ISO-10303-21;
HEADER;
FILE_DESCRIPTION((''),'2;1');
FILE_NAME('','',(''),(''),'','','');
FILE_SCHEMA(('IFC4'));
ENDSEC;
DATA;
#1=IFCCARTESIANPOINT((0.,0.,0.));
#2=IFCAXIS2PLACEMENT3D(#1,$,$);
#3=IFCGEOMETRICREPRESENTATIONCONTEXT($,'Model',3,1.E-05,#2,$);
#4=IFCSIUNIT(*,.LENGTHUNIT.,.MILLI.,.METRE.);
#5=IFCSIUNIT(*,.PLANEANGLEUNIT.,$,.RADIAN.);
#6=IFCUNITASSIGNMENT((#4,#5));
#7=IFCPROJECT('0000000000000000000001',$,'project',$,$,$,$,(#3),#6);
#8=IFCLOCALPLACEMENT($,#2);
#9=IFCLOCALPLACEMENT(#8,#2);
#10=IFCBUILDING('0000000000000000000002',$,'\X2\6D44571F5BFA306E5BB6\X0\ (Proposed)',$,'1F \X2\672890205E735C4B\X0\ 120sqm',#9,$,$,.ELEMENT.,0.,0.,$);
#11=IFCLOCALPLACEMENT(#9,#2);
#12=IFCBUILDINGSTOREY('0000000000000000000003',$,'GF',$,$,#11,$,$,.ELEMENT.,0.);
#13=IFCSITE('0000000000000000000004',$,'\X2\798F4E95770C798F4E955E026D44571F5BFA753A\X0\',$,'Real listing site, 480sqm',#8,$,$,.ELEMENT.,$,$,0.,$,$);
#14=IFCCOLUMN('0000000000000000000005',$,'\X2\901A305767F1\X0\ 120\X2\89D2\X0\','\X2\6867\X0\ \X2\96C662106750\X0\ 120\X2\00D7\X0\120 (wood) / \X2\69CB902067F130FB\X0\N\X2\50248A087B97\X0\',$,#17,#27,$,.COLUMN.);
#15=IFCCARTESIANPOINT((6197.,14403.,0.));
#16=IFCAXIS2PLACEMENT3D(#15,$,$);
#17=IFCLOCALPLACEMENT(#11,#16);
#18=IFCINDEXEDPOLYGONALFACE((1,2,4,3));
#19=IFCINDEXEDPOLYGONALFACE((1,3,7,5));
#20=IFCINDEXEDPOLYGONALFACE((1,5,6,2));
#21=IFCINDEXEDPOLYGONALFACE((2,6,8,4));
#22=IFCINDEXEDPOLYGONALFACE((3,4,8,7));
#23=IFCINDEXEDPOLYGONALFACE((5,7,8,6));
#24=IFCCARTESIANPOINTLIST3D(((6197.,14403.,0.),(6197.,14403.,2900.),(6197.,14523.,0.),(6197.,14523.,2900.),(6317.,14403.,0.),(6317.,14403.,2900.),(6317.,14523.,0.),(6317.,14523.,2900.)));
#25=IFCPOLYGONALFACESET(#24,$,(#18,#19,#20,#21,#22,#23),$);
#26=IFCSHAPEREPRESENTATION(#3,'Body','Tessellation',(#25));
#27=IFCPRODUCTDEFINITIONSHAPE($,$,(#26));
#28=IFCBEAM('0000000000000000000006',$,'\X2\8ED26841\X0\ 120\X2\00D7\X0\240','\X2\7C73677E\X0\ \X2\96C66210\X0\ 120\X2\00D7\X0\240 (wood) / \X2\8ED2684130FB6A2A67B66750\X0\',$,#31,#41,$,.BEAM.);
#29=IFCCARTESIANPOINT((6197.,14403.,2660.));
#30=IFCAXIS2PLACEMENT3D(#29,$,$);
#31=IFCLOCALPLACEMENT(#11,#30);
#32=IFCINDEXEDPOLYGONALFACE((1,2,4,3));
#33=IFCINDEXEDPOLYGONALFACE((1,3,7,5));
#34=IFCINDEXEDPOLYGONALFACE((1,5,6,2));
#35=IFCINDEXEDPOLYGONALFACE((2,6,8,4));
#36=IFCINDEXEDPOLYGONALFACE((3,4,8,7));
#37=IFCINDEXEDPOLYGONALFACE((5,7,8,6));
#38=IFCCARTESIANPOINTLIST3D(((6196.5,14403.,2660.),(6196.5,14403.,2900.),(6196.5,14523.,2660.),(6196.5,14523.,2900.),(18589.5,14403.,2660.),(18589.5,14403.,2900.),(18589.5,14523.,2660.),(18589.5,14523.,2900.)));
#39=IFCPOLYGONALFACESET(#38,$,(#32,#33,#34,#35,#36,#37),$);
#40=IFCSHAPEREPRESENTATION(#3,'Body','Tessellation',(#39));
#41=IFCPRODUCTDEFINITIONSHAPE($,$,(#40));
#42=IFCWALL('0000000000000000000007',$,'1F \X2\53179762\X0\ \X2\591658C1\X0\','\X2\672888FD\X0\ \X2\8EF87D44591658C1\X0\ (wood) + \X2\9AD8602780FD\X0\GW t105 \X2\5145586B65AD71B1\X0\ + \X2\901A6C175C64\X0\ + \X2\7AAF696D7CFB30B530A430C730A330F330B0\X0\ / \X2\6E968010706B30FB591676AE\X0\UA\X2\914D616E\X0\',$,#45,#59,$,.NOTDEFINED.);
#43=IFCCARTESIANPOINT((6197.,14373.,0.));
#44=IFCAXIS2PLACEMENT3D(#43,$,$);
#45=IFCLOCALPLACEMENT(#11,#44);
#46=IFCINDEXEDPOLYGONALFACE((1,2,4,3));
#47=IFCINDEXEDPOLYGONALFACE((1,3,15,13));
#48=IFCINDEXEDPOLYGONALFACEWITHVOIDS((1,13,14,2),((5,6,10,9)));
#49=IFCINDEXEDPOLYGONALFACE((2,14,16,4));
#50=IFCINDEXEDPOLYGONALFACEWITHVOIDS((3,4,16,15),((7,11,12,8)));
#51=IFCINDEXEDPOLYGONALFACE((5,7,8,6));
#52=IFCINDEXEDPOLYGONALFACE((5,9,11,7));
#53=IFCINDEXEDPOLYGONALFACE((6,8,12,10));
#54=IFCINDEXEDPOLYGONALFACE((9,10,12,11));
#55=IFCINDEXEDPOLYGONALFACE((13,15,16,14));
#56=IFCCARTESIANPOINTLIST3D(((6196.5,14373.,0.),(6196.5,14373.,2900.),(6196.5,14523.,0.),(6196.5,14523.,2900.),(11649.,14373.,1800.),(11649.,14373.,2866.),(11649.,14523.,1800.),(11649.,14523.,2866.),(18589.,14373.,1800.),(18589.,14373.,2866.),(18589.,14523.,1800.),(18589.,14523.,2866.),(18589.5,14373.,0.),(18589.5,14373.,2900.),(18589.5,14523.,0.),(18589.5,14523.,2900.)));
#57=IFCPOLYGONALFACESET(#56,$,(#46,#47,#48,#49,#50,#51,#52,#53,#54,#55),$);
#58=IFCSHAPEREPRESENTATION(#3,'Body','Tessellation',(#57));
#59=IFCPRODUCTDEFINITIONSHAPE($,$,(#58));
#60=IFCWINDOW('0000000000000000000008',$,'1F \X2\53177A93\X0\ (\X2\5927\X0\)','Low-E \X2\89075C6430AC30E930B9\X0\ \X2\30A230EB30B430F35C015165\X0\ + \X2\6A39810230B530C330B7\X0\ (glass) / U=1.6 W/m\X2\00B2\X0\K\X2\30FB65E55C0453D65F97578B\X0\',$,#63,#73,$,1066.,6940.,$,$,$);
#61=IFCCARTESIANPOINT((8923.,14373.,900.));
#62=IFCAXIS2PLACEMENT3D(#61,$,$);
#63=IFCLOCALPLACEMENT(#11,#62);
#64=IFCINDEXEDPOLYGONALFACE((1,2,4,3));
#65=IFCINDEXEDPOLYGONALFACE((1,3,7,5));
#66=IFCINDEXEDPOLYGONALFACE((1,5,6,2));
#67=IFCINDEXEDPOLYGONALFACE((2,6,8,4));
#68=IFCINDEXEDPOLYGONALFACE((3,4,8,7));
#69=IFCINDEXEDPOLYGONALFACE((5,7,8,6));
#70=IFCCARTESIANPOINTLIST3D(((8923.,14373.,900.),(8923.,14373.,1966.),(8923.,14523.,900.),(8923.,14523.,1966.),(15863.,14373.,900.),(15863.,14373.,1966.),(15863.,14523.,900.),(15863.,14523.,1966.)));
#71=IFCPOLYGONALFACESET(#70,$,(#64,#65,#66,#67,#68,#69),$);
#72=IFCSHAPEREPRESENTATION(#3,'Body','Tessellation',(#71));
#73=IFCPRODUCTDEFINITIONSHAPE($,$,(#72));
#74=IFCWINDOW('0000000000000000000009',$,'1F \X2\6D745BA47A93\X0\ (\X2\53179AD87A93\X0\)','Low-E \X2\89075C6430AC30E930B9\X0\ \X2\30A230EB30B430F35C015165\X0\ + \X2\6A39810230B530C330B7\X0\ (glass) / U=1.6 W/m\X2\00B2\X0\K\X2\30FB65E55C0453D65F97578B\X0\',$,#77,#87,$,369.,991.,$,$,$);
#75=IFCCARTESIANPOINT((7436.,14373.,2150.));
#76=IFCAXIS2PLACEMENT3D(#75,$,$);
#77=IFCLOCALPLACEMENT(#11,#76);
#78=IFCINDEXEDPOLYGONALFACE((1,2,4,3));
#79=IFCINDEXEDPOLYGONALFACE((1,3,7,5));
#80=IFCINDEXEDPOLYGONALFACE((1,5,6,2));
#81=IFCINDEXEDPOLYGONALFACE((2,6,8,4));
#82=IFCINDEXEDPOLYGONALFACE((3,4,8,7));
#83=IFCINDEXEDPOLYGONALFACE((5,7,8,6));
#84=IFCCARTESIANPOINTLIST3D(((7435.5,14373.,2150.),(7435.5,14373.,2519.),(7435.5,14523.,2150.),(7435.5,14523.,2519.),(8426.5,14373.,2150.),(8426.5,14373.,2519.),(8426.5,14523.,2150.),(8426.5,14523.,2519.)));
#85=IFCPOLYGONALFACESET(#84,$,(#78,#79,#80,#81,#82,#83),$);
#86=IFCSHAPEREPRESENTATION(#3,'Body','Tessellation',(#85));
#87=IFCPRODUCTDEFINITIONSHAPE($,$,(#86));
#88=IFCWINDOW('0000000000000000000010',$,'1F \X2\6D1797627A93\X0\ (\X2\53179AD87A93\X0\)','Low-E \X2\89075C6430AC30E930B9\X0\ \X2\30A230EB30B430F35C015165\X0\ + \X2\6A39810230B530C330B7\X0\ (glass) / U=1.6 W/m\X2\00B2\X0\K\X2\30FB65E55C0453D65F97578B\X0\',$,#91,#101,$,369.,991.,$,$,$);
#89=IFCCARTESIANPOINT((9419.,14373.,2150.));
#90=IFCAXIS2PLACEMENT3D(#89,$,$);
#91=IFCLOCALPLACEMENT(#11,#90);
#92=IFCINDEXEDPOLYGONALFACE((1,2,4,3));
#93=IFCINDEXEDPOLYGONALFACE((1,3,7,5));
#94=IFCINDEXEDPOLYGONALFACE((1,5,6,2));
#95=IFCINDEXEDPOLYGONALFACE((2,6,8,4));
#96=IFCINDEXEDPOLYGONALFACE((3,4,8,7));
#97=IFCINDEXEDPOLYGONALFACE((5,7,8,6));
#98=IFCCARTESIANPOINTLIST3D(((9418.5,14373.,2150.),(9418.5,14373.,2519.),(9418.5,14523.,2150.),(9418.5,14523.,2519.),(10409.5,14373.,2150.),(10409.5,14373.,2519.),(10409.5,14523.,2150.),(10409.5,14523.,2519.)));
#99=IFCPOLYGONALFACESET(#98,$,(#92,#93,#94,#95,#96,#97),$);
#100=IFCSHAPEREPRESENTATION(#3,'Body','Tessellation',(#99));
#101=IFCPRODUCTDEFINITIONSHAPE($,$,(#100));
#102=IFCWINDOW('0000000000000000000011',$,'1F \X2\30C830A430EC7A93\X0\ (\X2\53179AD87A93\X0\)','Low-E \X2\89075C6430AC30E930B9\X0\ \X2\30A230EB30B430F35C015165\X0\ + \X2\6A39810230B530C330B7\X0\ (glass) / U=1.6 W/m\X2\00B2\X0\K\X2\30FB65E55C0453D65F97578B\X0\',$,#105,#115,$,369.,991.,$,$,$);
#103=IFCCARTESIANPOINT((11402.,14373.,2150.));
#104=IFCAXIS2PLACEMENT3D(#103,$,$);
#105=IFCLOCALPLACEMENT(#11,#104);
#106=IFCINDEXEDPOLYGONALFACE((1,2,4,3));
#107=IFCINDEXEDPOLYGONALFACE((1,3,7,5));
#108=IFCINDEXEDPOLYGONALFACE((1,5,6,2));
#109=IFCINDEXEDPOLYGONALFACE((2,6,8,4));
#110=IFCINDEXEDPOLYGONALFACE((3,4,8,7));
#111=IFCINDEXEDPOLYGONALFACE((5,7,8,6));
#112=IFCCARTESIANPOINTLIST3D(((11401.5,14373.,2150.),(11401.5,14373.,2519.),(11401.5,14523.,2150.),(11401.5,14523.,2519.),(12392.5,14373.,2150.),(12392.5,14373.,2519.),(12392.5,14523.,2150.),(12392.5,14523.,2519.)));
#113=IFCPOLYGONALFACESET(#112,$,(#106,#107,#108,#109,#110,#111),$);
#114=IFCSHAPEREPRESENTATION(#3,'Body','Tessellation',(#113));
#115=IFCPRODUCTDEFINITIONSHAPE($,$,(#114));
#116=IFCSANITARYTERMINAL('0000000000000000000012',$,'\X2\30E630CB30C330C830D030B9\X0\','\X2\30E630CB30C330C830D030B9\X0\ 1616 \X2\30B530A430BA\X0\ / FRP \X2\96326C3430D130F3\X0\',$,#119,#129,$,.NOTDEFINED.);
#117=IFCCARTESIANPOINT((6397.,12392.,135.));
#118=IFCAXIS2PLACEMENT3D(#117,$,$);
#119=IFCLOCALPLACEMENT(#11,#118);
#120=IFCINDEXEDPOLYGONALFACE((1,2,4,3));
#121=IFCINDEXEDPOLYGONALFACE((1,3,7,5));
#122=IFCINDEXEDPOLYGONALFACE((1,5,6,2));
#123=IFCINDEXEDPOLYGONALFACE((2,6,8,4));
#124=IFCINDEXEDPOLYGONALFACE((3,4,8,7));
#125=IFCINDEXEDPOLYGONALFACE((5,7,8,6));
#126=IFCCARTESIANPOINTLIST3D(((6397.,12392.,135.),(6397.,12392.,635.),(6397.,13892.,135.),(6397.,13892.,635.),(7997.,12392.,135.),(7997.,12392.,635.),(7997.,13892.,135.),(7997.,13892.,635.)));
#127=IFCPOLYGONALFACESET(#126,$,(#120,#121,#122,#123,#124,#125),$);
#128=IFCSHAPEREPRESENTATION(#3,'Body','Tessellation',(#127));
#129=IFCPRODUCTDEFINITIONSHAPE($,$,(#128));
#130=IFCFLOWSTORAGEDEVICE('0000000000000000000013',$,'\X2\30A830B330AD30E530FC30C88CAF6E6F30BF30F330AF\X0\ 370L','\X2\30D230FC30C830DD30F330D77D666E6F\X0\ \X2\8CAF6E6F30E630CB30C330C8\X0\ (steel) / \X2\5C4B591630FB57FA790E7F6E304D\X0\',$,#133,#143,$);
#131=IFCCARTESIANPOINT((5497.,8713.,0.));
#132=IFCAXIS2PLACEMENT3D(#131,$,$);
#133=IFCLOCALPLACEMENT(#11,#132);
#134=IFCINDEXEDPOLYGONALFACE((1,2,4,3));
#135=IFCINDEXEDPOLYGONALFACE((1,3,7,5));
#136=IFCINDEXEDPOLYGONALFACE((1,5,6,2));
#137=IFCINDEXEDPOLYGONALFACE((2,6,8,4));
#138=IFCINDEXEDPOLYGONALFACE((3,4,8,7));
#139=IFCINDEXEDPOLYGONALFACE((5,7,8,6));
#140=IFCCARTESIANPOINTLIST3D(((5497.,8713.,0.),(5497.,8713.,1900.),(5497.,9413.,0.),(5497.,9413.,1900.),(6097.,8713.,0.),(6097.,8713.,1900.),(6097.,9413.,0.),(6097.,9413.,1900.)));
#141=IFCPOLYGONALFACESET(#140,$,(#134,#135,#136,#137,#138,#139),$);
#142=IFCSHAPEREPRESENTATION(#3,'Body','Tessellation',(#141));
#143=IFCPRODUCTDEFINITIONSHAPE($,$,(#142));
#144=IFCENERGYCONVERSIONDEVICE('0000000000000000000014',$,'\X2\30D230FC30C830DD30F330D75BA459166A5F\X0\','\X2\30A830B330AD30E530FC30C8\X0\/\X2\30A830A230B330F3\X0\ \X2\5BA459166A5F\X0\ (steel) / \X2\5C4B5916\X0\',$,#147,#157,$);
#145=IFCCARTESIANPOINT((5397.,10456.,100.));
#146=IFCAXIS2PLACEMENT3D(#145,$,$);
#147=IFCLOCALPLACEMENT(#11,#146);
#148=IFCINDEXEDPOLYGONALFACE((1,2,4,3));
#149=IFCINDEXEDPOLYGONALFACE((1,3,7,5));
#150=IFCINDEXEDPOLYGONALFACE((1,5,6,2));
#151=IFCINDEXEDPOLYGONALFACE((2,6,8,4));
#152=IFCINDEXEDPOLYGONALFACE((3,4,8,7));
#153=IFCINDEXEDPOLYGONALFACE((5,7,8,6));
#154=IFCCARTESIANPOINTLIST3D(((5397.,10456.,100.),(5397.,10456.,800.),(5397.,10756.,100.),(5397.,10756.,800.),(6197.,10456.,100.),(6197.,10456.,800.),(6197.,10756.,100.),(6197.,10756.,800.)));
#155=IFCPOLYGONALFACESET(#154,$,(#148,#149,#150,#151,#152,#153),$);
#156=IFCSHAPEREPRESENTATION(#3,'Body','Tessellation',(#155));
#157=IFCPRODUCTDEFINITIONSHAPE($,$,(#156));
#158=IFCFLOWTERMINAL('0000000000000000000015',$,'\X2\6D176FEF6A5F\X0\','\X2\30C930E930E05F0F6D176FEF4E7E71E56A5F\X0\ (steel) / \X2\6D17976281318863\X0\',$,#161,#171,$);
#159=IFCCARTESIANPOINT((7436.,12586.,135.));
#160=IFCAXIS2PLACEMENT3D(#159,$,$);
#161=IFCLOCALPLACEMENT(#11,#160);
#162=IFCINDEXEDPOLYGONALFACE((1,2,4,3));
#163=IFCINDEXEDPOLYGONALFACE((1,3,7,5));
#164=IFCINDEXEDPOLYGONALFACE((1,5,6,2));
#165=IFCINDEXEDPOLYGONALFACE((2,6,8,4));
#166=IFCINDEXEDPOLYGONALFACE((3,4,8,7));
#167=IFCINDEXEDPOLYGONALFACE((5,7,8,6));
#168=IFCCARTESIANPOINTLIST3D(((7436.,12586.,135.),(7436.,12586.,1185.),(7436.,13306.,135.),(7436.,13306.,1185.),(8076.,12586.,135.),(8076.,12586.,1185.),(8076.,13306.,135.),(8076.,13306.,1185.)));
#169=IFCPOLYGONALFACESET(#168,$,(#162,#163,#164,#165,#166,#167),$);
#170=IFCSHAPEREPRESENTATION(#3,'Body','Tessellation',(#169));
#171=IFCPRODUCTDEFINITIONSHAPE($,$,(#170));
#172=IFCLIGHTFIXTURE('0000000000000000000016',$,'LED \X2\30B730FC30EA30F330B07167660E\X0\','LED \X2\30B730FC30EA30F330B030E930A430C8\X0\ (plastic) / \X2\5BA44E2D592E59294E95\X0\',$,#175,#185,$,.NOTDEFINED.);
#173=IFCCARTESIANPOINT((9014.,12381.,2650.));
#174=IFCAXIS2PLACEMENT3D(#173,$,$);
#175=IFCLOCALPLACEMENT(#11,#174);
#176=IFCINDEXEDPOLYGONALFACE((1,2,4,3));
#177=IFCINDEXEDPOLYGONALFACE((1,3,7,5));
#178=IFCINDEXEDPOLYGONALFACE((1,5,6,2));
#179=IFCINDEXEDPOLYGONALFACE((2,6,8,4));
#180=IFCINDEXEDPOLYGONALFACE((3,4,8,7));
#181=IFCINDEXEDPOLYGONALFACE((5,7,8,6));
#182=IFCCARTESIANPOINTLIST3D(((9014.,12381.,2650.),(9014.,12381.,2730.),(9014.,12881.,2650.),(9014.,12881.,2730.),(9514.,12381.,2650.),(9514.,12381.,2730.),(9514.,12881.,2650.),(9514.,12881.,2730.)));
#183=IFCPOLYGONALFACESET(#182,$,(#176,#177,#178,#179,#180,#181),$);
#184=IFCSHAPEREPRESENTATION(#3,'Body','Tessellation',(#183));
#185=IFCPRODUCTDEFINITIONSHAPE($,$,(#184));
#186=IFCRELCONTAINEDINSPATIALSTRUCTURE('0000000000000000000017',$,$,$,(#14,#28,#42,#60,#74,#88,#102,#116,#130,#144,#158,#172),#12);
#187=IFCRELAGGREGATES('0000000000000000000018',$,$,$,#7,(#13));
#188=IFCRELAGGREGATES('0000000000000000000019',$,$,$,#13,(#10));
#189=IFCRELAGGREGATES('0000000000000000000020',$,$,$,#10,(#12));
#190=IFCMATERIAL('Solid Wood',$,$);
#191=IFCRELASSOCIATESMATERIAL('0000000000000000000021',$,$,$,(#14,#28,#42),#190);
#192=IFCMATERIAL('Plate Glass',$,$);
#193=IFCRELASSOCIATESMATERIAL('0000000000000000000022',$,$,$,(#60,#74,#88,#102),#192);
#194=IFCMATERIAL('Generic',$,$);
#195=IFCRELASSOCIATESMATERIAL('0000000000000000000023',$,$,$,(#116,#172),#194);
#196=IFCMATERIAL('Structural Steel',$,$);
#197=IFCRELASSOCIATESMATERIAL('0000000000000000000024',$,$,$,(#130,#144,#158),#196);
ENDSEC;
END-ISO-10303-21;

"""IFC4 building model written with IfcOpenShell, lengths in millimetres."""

from ifc_helpers import new_model, si_unit, frame, frame_2d, origin, place, context, project, spatial, rectangle, extrude, material, element, fill, save


model = new_model("IFC4")

# Units and contexts
model_context = context("Model", 3, precision=1e-05, world=origin())
ifc_project = project(units=[si_unit("LENGTHUNIT", "METRE", prefix="MILLI"), si_unit("PLANEANGLEUNIT", "RADIAN")], contexts=[model_context])

# Site, building, storey
site_placement = place(None, origin())
site = spatial("IfcSite", under=ifc_project, at=site_placement, Name="福井県福井市浄土寺町", ObjectType="Real listing site, 480sqm", CompositionType="ELEMENT", RefElevation=0.0)
building_placement = place(site_placement, origin())
building = spatial("IfcBuilding", under=site, at=building_placement, Name="浄土寺の家 (Proposed)", ObjectType="1F 木造平屋 120sqm", CompositionType="ELEMENT", ElevationOfRefHeight=0.0, ElevationOfTerrain=0.0)
storey_placement = place(building_placement, origin())
storey = spatial("IfcBuildingStorey", under=building, at=storey_placement, Name="GF", CompositionType="ELEMENT", Elevation=0.0)

# Column
ifc_material_1 = material(Name="Solid Wood")
column_1_placement = place(storey_placement, frame((6197.0, 14403.0, 0.0)))
element("IfcColumn", 1, at=column_1_placement, inside=storey, material=ifc_material_1, Name="通し柱 120角", Description="桧 集成材 120×120 (wood) / 構造柱・N値計算", PredefinedType="COLUMN", context=model_context, shape_type="SweptSolid", body=[
    extrude(rectangle(XDim=120.0, YDim=120.0, at=frame_2d((60.0, 60.0))), frame((6197.0, 14403.0, 0.0)), (0.0, 0.0, 1.0), 2900.0),
])

# Beam
beam_1_placement = place(storey_placement, frame((6197.0, 14403.0, 2660.0)))
element("IfcBeam", 2, at=beam_1_placement, inside=storey, material=ifc_material_1, Name="軒桁 120×240", Description="米松 集成 120×240 (wood) / 軒桁・横架材", PredefinedType="BEAM", context=model_context, shape_type="SweptSolid", body=[
    extrude(rectangle(XDim=12393.0, YDim=120.0, at=frame_2d((6196.0, 60.0))), frame((6197.0, 14403.0, 2660.0)), (0.0, 0.0, 1.0), 240.0),
])

# Wall, openings, windows
wall_1_placement = place(storey_placement, frame((6197.0, 14373.0, 0.0)))
wall_1 = element("IfcWall", 3, at=wall_1_placement, inside=storey, material=ifc_material_1, Name="1F 北面 外壁", Description="木製 軸組外壁 (wood) + 高性能GW t105 充填断熱 + 通気層 + 窯業系サイディング / 準耐火・外皮UA配慮", PredefinedType="NOTDEFINED", context=model_context, shape_type="SweptSolid", body=[
    extrude(rectangle(XDim=12393.0, YDim=150.0, at=frame_2d((6196.0, 75.0))), frame((6197.0, 14373.0, 0.0)), (0.0, 0.0, 1.0), 2900.0),
])
opening_1_placement = place(storey_placement, frame((8923.0, 14373.0, 900.0)))
opening_1 = element("IfcOpeningElement", 4, at=opening_1_placement, cuts=wall_1, PredefinedType="NOTDEFINED", context=model_context, shape_type="SweptSolid", body=[
    extrude(rectangle(XDim=6940.0, YDim=150.0, at=frame_2d((3470.0, 75.0))), frame((8923.0, 14373.0, 900.0)), (0.0, 0.0, 1.0), 1066.0),
])
opening_2_placement = place(storey_placement, frame((7436.0, 14373.0, 2150.0)))
opening_2 = element("IfcOpeningElement", 5, at=opening_2_placement, cuts=wall_1, PredefinedType="NOTDEFINED", context=model_context, shape_type="SweptSolid", body=[
    extrude(rectangle(XDim=991.0, YDim=150.0, at=frame_2d((495.0, 75.0))), frame((7436.0, 14373.0, 2150.0)), (0.0, 0.0, 1.0), 369.0),
])
opening_3_placement = place(storey_placement, frame((9419.0, 14373.0, 2150.0)))
opening_3 = element("IfcOpeningElement", 6, at=opening_3_placement, cuts=wall_1, PredefinedType="NOTDEFINED", context=model_context, shape_type="SweptSolid", body=[
    extrude(rectangle(XDim=991.0, YDim=150.0, at=frame_2d((495.0, 75.0))), frame((9419.0, 14373.0, 2150.0)), (0.0, 0.0, 1.0), 369.0),
])
opening_4_placement = place(storey_placement, frame((11402.0, 14373.0, 2150.0)))
opening_4 = element("IfcOpeningElement", 7, at=opening_4_placement, cuts=wall_1, PredefinedType="NOTDEFINED", context=model_context, shape_type="SweptSolid", body=[
    extrude(rectangle(XDim=991.0, YDim=150.0, at=frame_2d((495.0, 75.0))), frame((11402.0, 14373.0, 2150.0)), (0.0, 0.0, 1.0), 369.0),
])
ifc_material_2 = material(Name="Plate Glass")
window_1_placement = place(storey_placement, frame((8923.0, 14373.0, 900.0)))
window_1 = element("IfcWindow", 8, at=window_1_placement, inside=storey, material=ifc_material_2, Name="1F 北窓 (大)", Description="Low-E 複層ガラス アルゴン封入 + 樹脂サッシ (glass) / U=1.6 W/m²K・日射取得型", OverallHeight=1066.0, OverallWidth=6940.0, context=model_context, shape_type="SweptSolid", body=[
    extrude(rectangle(XDim=6940.0, YDim=150.0, at=frame_2d((3470.0, 75.0))), frame((8923.0, 14373.0, 900.0)), (0.0, 0.0, 1.0), 1066.0),
])
fill(opening_1, window_1)
window_2_placement = place(storey_placement, frame((7436.0, 14373.0, 2150.0)))
window_2 = element("IfcWindow", 9, at=window_2_placement, inside=storey, material=ifc_material_2, Name="1F 浴室窓 (北高窓)", Description="Low-E 複層ガラス アルゴン封入 + 樹脂サッシ (glass) / U=1.6 W/m²K・日射取得型", OverallHeight=369.0, OverallWidth=991.0, context=model_context, shape_type="SweptSolid", body=[
    extrude(rectangle(XDim=991.0, YDim=150.0, at=frame_2d((495.0, 75.0))), frame((7436.0, 14373.0, 2150.0)), (0.0, 0.0, 1.0), 369.0),
])
fill(opening_2, window_2)
window_3_placement = place(storey_placement, frame((9419.0, 14373.0, 2150.0)))
window_3 = element("IfcWindow", 10, at=window_3_placement, inside=storey, material=ifc_material_2, Name="1F 洗面窓 (北高窓)", Description="Low-E 複層ガラス アルゴン封入 + 樹脂サッシ (glass) / U=1.6 W/m²K・日射取得型", OverallHeight=369.0, OverallWidth=991.0, context=model_context, shape_type="SweptSolid", body=[
    extrude(rectangle(XDim=991.0, YDim=150.0, at=frame_2d((495.0, 75.0))), frame((9419.0, 14373.0, 2150.0)), (0.0, 0.0, 1.0), 369.0),
])
fill(opening_3, window_3)
window_4_placement = place(storey_placement, frame((11402.0, 14373.0, 2150.0)))
window_4 = element("IfcWindow", 11, at=window_4_placement, inside=storey, material=ifc_material_2, Name="1F トイレ窓 (北高窓)", Description="Low-E 複層ガラス アルゴン封入 + 樹脂サッシ (glass) / U=1.6 W/m²K・日射取得型", OverallHeight=369.0, OverallWidth=991.0, context=model_context, shape_type="SweptSolid", body=[
    extrude(rectangle(XDim=991.0, YDim=150.0, at=frame_2d((495.0, 75.0))), frame((11402.0, 14373.0, 2150.0)), (0.0, 0.0, 1.0), 369.0),
])
fill(opening_4, window_4)

# Sanitary terminal
ifc_material_3 = material(Name="Generic")
sanitary_terminal_placement = place(storey_placement, frame((6397.0, 12392.0, 135.0)))
element("IfcSanitaryTerminal", 12, at=sanitary_terminal_placement, inside=storey, material=ifc_material_3, Name="ユニットバス", Description="ユニットバス 1616 サイズ / FRP 防水パン", PredefinedType="NOTDEFINED", context=model_context, shape_type="SweptSolid", body=[
    extrude(rectangle(XDim=1600.0, YDim=1500.0, at=frame_2d((800.0, 750.0))), frame((6397.0, 12392.0, 135.0)), (0.0, 0.0, 1.0), 500.0),
])

# Flow storage device
ifc_material_4 = material(Name="Structural Steel")
flow_storage_device_placement = place(storey_placement, frame((5497.0, 8713.0, 0.0)))
element("IfcFlowStorageDevice", 13, at=flow_storage_device_placement, inside=storey, material=ifc_material_4, Name="エコキュート貯湯タンク 370L", Description="ヒートポンプ給湯 貯湯ユニット (steel) / 屋外・基礎置き", context=model_context, shape_type="SweptSolid", body=[
    extrude(rectangle(XDim=600.0, YDim=700.0, at=frame_2d((300.0, 350.0))), frame((5497.0, 8713.0, 0.0)), (0.0, 0.0, 1.0), 1900.0),
])

# Energy conversion device
energy_conversion_device_placement = place(storey_placement, frame((5397.0, 10456.0, 100.0)))
element("IfcEnergyConversionDevice", 14, at=energy_conversion_device_placement, inside=storey, material=ifc_material_4, Name="ヒートポンプ室外機", Description="エコキュート/エアコン 室外機 (steel) / 屋外", context=model_context, shape_type="SweptSolid", body=[
    extrude(rectangle(XDim=800.0, YDim=300.0, at=frame_2d((400.0, 150.0))), frame((5397.0, 10456.0, 100.0)), (0.0, 0.0, 1.0), 700.0),
])

# Flow terminal
flow_terminal_placement = place(storey_placement, frame((7436.0, 12586.0, 135.0)))
element("IfcFlowTerminal", 15, at=flow_terminal_placement, inside=storey, material=ifc_material_4, Name="洗濯機", Description="ドラム式洗濯乾燥機 (steel) / 洗面脱衣", context=model_context, shape_type="SweptSolid", body=[
    extrude(rectangle(XDim=640.0, YDim=720.0, at=frame_2d((320.0, 360.0))), frame((7436.0, 12586.0, 135.0)), (0.0, 0.0, 1.0), 1050.0),
])

# Light fixture
light_fixture_placement = place(storey_placement, frame((9014.0, 12381.0, 2650.0)))
element("IfcLightFixture", 16, at=light_fixture_placement, inside=storey, material=ifc_material_3, Name="LED シーリング照明", Description="LED シーリングライト (plastic) / 室中央天井", PredefinedType="NOTDEFINED", context=model_context, shape_type="SweptSolid", body=[
    extrude(rectangle(XDim=500.0, YDim=500.0, at=frame_2d((250.0, 250.0))), frame((9014.0, 12381.0, 2650.0)), (0.0, 0.0, 1.0), 80.0),
])

save(model, "model.ifc")
